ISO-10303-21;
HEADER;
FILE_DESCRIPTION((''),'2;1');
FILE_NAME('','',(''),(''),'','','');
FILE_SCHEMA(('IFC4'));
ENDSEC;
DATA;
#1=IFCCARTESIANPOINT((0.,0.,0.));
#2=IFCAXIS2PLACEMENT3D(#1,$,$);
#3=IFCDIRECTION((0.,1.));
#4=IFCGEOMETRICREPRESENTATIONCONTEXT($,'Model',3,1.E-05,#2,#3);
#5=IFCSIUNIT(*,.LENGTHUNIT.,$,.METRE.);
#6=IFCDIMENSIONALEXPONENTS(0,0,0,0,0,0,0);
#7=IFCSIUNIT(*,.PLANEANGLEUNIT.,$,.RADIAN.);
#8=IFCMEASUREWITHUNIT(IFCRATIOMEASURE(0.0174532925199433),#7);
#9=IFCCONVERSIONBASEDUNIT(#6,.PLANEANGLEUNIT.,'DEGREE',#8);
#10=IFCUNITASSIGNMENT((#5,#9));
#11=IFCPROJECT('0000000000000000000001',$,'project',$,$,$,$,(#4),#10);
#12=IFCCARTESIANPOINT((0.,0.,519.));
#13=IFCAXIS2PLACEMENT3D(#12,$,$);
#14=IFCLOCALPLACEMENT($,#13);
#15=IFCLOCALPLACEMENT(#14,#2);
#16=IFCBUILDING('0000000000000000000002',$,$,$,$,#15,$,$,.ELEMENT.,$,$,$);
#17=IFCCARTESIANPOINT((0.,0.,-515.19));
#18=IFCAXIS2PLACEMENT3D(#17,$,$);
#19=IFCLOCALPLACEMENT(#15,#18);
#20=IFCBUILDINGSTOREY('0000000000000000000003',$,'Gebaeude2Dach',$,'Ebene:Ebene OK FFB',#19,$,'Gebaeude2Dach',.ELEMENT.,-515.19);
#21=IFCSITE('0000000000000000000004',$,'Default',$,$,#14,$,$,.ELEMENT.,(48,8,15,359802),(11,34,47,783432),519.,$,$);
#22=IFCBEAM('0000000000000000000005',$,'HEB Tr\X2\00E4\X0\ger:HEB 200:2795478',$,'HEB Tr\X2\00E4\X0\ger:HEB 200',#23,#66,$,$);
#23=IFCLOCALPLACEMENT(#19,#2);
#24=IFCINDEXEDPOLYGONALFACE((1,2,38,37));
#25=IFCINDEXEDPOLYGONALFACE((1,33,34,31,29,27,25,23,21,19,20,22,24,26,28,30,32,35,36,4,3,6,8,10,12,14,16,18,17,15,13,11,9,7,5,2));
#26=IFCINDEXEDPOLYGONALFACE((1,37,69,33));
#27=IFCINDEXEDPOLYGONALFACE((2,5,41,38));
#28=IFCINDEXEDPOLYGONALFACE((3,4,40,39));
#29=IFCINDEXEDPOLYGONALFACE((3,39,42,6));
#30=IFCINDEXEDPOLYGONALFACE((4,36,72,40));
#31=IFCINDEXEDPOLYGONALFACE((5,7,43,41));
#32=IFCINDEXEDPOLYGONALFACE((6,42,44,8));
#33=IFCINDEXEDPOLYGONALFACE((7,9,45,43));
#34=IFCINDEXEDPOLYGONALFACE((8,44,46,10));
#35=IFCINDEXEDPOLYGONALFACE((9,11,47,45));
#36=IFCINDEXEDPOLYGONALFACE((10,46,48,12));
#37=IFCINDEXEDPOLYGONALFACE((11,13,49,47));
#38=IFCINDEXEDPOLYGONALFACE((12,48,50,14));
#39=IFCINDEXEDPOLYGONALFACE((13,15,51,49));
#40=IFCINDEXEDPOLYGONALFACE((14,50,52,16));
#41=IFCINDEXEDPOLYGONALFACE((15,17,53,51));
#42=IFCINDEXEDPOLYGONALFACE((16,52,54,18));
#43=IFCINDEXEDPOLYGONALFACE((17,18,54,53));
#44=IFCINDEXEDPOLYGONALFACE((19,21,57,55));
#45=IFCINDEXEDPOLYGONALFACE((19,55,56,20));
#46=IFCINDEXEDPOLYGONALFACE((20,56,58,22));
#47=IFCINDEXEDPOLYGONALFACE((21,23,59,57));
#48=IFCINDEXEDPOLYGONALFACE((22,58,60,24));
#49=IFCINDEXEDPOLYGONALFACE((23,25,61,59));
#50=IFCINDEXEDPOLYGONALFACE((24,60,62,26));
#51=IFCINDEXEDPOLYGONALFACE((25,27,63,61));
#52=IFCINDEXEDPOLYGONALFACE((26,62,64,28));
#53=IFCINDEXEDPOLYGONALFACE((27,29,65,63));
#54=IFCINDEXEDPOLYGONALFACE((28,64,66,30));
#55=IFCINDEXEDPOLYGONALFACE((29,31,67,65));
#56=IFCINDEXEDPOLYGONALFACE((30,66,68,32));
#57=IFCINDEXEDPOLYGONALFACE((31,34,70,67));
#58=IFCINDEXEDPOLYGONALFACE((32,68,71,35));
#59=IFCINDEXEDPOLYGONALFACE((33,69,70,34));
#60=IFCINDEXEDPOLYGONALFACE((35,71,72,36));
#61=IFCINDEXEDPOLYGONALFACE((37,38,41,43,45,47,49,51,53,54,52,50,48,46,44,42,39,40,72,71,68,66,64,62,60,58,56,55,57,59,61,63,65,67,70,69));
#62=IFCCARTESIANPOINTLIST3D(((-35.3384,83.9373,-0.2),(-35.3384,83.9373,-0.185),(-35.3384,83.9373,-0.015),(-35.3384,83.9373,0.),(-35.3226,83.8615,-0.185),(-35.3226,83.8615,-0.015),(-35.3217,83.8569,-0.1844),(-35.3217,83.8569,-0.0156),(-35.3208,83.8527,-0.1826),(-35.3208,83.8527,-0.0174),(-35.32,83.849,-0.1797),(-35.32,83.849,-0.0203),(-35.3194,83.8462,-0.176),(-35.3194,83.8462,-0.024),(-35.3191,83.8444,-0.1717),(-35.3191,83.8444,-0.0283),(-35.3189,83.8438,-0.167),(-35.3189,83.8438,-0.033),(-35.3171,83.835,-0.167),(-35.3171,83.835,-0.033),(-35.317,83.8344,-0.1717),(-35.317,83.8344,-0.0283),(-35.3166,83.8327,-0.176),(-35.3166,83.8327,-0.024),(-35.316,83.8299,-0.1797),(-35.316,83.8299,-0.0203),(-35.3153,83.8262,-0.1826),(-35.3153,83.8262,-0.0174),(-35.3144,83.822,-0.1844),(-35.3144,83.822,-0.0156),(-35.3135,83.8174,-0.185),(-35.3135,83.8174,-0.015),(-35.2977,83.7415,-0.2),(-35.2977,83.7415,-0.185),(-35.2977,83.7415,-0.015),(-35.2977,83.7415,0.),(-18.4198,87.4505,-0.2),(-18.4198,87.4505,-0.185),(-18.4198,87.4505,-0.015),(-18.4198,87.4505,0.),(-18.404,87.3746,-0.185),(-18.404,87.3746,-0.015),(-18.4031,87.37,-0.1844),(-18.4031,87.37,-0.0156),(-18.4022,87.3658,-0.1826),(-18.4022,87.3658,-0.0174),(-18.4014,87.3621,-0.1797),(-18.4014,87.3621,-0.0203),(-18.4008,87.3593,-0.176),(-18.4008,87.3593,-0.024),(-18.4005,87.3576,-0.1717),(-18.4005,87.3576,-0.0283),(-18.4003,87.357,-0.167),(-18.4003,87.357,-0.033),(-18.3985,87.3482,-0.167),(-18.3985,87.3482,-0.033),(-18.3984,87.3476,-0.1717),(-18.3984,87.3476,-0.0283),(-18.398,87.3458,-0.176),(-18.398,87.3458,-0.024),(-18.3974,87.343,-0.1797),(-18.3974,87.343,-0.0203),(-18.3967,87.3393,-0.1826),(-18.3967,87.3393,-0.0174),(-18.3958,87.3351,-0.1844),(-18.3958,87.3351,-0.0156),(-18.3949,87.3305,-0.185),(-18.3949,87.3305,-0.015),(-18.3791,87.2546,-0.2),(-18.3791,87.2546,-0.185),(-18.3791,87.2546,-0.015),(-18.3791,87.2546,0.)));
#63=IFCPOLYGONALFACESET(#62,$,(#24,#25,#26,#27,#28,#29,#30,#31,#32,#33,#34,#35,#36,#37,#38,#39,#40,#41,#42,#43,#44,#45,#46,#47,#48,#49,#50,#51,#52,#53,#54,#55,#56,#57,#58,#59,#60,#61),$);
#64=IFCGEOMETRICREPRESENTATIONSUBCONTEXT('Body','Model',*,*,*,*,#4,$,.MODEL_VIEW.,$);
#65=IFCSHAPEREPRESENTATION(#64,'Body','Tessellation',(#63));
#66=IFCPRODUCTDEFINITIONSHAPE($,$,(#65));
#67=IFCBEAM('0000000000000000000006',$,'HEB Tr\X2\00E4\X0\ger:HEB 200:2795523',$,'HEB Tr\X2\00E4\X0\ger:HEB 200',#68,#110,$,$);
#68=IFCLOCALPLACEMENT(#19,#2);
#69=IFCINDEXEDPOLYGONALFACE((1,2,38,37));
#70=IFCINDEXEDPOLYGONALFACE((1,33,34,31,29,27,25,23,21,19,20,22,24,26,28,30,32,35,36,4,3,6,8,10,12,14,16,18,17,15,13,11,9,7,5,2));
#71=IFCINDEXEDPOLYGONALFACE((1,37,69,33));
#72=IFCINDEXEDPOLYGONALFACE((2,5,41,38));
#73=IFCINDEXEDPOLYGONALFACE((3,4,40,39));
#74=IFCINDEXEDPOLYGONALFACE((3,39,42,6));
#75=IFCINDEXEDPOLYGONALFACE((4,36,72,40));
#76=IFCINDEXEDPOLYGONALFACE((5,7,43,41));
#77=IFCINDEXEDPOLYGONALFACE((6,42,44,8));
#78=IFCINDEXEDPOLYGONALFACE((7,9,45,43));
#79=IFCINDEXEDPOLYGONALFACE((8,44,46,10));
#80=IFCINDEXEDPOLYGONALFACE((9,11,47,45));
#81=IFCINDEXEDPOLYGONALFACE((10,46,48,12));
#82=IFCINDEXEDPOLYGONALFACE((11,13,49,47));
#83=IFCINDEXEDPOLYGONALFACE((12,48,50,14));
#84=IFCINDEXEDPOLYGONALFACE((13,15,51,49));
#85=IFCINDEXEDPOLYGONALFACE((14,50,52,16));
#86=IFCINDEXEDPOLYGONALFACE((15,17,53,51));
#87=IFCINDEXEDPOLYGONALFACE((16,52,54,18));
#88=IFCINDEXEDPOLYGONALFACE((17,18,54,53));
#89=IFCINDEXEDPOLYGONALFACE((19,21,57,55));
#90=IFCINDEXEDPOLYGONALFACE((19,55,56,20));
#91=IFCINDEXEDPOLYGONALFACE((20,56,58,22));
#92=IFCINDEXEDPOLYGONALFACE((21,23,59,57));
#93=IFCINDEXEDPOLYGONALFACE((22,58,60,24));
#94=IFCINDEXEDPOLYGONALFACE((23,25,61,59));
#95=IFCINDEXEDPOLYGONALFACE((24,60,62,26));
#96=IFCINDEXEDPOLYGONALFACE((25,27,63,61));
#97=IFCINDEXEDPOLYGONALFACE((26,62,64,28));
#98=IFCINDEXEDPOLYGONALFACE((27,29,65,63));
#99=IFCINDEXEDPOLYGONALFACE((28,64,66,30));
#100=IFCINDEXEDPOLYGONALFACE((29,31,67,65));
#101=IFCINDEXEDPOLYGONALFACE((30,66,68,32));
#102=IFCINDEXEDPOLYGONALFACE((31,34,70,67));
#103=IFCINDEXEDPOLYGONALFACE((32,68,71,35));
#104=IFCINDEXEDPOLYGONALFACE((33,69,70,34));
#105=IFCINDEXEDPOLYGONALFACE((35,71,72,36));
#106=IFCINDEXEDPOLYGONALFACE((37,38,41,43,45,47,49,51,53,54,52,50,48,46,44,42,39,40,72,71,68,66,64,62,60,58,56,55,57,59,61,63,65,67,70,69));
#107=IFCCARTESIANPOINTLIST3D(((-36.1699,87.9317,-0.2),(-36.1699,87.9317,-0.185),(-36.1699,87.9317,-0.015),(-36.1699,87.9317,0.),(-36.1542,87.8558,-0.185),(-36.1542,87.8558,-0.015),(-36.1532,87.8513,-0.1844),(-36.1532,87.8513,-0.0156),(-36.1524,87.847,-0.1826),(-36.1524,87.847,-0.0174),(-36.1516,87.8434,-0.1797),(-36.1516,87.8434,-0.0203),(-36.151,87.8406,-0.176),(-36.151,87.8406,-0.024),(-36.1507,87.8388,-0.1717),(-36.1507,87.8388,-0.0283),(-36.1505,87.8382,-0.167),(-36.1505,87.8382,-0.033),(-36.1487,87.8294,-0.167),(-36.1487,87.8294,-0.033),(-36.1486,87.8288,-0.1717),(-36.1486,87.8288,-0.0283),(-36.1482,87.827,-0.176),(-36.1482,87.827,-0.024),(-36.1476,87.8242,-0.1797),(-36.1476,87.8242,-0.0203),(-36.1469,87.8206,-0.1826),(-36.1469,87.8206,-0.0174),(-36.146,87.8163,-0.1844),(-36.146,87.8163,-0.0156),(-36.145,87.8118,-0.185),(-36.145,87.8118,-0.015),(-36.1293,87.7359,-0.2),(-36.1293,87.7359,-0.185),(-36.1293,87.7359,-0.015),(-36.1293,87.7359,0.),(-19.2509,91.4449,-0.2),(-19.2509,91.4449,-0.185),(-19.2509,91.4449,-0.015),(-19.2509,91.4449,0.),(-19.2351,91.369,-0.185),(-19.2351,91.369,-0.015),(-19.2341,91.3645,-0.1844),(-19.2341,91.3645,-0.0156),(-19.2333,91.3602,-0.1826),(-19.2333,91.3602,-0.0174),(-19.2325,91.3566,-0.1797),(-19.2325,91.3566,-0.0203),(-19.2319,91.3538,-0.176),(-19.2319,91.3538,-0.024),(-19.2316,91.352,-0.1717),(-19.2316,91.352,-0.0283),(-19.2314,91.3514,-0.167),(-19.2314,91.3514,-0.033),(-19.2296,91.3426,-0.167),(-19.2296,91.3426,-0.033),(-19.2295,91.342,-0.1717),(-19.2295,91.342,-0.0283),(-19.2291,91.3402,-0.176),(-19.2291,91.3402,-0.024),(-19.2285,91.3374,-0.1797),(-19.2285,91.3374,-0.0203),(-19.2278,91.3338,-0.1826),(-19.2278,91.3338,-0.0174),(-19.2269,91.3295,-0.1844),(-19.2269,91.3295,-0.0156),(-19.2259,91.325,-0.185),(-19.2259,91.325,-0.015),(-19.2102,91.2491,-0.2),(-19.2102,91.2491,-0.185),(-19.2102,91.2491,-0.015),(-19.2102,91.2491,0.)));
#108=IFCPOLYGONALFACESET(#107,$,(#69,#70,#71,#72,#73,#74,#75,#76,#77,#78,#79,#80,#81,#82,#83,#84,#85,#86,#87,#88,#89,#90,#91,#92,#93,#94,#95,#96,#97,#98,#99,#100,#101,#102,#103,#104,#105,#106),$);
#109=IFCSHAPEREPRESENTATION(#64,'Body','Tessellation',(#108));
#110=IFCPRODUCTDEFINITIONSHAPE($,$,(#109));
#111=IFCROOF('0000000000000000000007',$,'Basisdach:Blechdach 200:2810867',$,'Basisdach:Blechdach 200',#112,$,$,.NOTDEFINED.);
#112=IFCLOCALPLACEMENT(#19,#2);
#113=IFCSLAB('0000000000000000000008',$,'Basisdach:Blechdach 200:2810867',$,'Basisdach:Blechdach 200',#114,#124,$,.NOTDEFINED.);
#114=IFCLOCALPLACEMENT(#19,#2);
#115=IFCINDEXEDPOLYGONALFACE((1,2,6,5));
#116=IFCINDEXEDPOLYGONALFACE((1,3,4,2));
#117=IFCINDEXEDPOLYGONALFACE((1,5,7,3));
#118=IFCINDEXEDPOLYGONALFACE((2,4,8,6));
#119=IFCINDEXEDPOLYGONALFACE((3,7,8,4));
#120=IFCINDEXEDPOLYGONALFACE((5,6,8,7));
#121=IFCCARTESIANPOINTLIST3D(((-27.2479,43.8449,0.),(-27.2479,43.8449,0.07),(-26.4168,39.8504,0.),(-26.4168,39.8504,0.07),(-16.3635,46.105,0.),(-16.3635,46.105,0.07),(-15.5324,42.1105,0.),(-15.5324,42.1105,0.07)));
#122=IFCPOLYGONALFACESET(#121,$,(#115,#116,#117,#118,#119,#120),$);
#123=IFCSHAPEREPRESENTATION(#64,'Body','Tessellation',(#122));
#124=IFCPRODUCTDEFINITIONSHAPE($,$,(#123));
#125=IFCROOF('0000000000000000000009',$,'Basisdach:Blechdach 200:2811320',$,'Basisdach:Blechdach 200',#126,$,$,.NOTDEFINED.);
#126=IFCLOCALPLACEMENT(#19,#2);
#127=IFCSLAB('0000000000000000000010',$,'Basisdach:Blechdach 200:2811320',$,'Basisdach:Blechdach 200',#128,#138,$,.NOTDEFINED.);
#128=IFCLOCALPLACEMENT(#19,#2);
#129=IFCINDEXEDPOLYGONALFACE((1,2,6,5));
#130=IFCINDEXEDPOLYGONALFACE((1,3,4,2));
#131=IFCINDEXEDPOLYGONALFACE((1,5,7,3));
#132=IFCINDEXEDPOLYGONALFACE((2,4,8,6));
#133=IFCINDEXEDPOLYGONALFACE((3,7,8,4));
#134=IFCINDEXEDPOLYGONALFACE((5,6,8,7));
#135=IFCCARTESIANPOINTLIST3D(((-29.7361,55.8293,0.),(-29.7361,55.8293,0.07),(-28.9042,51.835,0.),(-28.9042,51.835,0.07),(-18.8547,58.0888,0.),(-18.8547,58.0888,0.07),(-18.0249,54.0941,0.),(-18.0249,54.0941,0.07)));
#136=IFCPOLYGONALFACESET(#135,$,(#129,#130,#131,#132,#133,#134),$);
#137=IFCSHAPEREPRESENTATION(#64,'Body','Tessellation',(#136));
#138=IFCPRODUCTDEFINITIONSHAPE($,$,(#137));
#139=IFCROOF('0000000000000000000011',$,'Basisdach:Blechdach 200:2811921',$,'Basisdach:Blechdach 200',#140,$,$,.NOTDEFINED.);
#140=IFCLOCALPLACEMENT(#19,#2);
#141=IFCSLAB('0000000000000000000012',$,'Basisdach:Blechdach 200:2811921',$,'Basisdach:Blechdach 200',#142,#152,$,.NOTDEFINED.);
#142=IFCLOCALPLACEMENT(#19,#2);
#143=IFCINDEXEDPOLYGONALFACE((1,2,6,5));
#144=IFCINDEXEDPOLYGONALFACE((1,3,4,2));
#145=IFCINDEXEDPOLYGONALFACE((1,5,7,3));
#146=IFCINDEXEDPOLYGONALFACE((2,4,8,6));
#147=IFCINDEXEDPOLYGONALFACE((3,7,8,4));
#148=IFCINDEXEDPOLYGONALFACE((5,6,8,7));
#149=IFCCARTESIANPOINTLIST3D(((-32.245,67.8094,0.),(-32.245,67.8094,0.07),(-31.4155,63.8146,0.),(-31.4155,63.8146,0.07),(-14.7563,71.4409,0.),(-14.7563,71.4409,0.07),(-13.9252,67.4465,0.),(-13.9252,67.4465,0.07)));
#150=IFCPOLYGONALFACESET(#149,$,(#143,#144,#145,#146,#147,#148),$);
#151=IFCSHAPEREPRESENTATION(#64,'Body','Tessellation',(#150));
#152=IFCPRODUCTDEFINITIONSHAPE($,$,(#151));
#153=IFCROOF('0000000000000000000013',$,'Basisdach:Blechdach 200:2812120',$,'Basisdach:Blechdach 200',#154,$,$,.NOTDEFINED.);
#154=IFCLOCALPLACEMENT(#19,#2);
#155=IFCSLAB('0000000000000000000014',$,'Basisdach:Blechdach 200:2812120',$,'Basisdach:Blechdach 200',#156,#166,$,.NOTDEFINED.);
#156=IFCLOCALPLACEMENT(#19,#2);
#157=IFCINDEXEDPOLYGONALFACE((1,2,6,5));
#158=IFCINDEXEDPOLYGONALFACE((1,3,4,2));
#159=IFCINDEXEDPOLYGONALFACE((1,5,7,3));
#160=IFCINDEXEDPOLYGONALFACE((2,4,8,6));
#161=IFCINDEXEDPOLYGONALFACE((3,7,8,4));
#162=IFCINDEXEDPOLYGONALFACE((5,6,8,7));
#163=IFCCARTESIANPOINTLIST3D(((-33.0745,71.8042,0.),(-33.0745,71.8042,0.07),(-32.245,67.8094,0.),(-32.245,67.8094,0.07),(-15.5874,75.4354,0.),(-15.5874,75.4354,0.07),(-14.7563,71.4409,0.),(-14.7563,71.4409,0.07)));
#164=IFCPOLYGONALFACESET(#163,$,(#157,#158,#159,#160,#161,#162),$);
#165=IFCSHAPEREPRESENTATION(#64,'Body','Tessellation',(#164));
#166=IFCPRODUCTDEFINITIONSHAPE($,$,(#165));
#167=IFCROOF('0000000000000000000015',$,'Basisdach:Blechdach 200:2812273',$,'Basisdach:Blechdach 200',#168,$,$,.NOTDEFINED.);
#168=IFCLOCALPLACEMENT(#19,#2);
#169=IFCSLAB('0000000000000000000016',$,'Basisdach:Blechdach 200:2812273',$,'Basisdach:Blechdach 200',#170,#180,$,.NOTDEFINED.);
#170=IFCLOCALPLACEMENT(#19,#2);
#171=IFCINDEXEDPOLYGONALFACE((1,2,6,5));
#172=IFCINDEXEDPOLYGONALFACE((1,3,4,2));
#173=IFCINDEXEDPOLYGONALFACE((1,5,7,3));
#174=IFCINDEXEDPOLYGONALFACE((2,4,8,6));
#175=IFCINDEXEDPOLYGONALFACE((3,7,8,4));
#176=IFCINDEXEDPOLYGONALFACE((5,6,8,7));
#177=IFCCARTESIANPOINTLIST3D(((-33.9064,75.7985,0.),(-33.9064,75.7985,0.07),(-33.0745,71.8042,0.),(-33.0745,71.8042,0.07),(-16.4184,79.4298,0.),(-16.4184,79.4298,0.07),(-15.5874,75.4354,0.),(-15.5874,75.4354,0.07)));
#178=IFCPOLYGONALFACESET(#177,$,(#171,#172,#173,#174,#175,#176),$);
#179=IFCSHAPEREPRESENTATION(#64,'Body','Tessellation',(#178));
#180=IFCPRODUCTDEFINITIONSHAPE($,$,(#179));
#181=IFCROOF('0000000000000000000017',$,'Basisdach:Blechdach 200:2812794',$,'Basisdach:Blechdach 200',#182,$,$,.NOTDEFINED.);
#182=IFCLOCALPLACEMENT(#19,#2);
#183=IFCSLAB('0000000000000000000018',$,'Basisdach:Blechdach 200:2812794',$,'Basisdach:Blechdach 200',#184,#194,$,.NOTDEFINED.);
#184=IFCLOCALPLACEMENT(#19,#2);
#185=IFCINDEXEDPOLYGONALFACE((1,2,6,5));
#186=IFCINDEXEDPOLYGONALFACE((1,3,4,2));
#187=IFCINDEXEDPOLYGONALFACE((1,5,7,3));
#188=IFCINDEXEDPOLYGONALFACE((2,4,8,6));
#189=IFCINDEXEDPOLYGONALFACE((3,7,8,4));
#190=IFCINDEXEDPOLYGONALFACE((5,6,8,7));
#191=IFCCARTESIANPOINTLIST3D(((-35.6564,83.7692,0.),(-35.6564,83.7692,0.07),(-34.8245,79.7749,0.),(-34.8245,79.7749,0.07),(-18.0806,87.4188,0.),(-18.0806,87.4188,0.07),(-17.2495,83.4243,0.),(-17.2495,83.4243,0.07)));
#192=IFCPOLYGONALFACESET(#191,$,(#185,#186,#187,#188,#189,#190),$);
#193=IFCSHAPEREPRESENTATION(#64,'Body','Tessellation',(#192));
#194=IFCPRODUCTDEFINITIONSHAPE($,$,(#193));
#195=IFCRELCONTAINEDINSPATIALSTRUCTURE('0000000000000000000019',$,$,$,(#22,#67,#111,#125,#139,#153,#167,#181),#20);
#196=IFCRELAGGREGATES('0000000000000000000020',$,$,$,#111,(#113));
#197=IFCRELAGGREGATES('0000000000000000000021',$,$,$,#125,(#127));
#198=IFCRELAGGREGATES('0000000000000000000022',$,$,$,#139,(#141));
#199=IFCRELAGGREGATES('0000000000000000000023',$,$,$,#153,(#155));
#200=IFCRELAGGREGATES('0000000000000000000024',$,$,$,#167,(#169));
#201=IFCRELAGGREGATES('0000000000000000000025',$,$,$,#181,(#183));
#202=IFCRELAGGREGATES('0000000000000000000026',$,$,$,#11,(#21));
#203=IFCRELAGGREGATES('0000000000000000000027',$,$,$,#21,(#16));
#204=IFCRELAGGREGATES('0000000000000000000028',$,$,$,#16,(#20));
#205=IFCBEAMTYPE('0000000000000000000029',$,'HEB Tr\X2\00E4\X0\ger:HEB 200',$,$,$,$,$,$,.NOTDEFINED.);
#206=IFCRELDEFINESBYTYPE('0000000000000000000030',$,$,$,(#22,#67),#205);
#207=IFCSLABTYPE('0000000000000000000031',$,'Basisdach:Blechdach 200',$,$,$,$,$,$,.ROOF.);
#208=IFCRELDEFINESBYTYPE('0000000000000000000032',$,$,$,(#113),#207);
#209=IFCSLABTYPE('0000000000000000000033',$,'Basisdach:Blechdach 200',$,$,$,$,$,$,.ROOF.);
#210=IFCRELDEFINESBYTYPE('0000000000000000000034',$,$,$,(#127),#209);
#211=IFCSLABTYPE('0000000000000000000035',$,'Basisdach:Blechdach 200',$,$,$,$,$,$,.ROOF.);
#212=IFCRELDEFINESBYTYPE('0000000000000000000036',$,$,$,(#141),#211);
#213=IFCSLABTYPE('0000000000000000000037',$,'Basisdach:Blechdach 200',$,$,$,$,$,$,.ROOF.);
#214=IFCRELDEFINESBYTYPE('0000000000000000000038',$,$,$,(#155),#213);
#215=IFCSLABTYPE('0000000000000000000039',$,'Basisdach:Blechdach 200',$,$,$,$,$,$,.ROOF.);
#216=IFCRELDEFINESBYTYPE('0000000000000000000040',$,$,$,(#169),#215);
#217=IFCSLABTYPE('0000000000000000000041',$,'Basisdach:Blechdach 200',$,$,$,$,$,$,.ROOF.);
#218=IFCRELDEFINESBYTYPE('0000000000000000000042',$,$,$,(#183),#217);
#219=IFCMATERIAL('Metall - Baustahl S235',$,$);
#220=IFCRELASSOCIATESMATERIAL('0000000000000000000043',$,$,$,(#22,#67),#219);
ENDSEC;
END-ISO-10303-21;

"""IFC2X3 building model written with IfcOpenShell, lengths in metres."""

from ifc_helpers import new_model, entity, si_unit, converted_unit, direction, frame, frame_2d, origin, place, context, subcontext, project, spatial, polyline, i_section, outline, extrude, material, type_object, element, aggregate, save


model = new_model("IFC2X3")

# Units and contexts
model_context = context("Model", 3, precision=1e-05, world=origin(), true_north=direction((0.0, 1.0)))
body_context = subcontext(model_context, "Body", "Model", "MODEL_VIEW")
ifc_project = project(units=[si_unit("LENGTHUNIT", "METRE"), converted_unit("PLANEANGLEUNIT", "DEGREE", entity("IfcRatioMeasure", 0.0174532925199433), si_unit("PLANEANGLEUNIT", "RADIAN"), dimensions=[0, 0, 0, 0, 0, 0, 0])], contexts=[model_context])

# Site, building, storey
site_placement = place(None, frame((0.0, 0.0, 519.0)))
site = spatial("IfcSite", under=ifc_project, at=site_placement, Name="Default", CompositionType="ELEMENT", RefLatitude=(48, 8, 15, 359802), RefLongitude=(11, 34, 47, 783432), RefElevation=519.0)
building_placement = place(site_placement, origin())
building = spatial("IfcBuilding", under=site, at=building_placement, CompositionType="ELEMENT")
storey_placement = place(building_placement, frame((0.0, 0.0, -515.19)))
storey = spatial("IfcBuildingStorey", under=building, at=storey_placement, Name="Gebaeude2Dach", ObjectType="Ebene:Ebene OK FFB", LongName="Gebaeude2Dach", CompositionType="ELEMENT", Elevation=-515.19)

# Beams
ifc_material = material(Name="Metall - Baustahl S235")
beam_type = type_object("IfcBeamType", Name="HEB Träger:HEB 200", PredefinedType="NOTDEFINED")
beam_1_placement = place(storey_placement, frame((-18.2861, 87.3761, 0.0), z_axis=(0.0, 0.0, 1.0), x_axis=(-0.979114, -0.203311, 0.0)))
element("IfcBeam", 1, at=beam_1_placement, inside=storey, type_object=beam_type, material=ifc_material, Name="HEB Träger:HEB 200:2795478", ObjectType="HEB Träger:HEB 200", context=body_context, shape_type="SweptSolid", body=[
    extrude(i_section(OverallWidth=0.2, OverallDepth=0.2, WebThickness=0.009, FlangeThickness=0.015, FilletRadius=0.018, at=frame_2d((0.0, 0.0), x_axis=(0.0, 1.0))), frame((0.1158, 0.0, -0.1), z_axis=(1.0, 0.0, 0.0), x_axis=(0.0, 0.0, -1.0)), (0.0, 0.0, 1.0), 17.2795),
])
beam_2_placement = place(storey_placement, frame((-19.1171, 91.3706, 0.0), z_axis=(0.0, 0.0, 1.0), x_axis=(-0.979114, -0.203311, 0.0)))
element("IfcBeam", 2, at=beam_2_placement, inside=storey, type_object=beam_type, material=ifc_material, Name="HEB Träger:HEB 200:2795523", ObjectType="HEB Träger:HEB 200", context=body_context, shape_type="SweptSolid", body=[
    extrude(i_section(OverallWidth=0.2, OverallDepth=0.2, WebThickness=0.009, FlangeThickness=0.015, FilletRadius=0.018, at=frame_2d((0.0, 0.0), x_axis=(0.0, 1.0))), frame((0.1158, 0.0, -0.1), z_axis=(1.0, 0.0, 0.0), x_axis=(0.0, 0.0, -1.0)), (0.0, 0.0, 1.0), 17.28),
])

# Roofs, slabs
roof_1_placement = place(storey_placement, frame((-27.2479, 39.8504, 0.0)))
roof_1 = element("IfcRoof", 3, at=roof_1_placement, inside=storey, Name="Basisdach:Blechdach 200:2810867", ObjectType="Basisdach:Blechdach 200", ShapeType="NOTDEFINED")
slab_type_1 = type_object("IfcSlabType", Name="Basisdach:Blechdach 200", PredefinedType="ROOF")
slab_1_placement = place(roof_1_placement, origin())
slab_1 = element("IfcSlab", 4, at=slab_1_placement, type_object=slab_type_1, Name="Basisdach:Blechdach 200:2810867", ObjectType="Basisdach:Blechdach 200", PredefinedType="NOTDEFINED", context=body_context, shape_type="SweptSolid", body=[
    extrude(outline(polyline([(5.8577, -0.8672), (5.0267, 3.1273), (-5.8577, 0.8672), (-5.0267, -3.1273), (5.8577, -0.8672)])), frame((5.8577, 3.1273, 0.0)), (0.0, 0.0, 1.0), 0.07),
])
aggregate(roof_1, [slab_1])
roof_2_placement = place(storey_placement, frame((-29.7361, 51.835, 0.0)))
roof_2 = element("IfcRoof", 5, at=roof_2_placement, inside=storey, Name="Basisdach:Blechdach 200:2811320", ObjectType="Basisdach:Blechdach 200", ShapeType="NOTDEFINED")
slab_type_2 = type_object("IfcSlabType", Name="Basisdach:Blechdach 200", PredefinedType="ROOF")
slab_2_placement = place(roof_2_placement, origin())
slab_2 = element("IfcSlab", 6, at=slab_2_placement, type_object=slab_type_2, Name="Basisdach:Blechdach 200:2811320", ObjectType="Basisdach:Blechdach 200", PredefinedType="NOTDEFINED", context=body_context, shape_type="SweptSolid", body=[
    extrude(outline(polyline([(5.8556, -0.8678), (5.0258, 3.1269), (-5.8556, 0.8674), (-5.0237, -3.1269), (5.8556, -0.8678)])), frame((5.8556, 3.1269, 0.0)), (0.0, 0.0, 1.0), 0.07),
])
aggregate(roof_2, [slab_2])
roof_3_placement = place(storey_placement, frame((-32.245, 63.8146, 0.0)))
roof_3 = element("IfcRoof", 7, at=roof_3_placement, inside=storey, Name="Basisdach:Blechdach 200:2811921", ObjectType="Basisdach:Blechdach 200", ShapeType="NOTDEFINED")
slab_type_3 = type_object("IfcSlabType", Name="Basisdach:Blechdach 200", PredefinedType="ROOF")
slab_3_placement = place(roof_3_placement, origin())
slab_3 = element("IfcSlab", 8, at=slab_3_placement, type_object=slab_type_3, Name="Basisdach:Blechdach 200:2811921", ObjectType="Basisdach:Blechdach 200", PredefinedType="NOTDEFINED", context=body_context, shape_type="SweptSolid", body=[
    extrude(outline(polyline([(9.1599, -0.1813), (8.3288, 3.8131), (-9.1599, 0.1816), (-8.3304, -3.8131), (9.1599, -0.1813)])), frame((9.1599, 3.8131, 0.0)), (0.0, 0.0, 1.0), 0.07),
])
aggregate(roof_3, [slab_3])
roof_4_placement = place(storey_placement, frame((-33.0745, 67.8094, 0.0)))
roof_4 = element("IfcRoof", 9, at=roof_4_placement, inside=storey, Name="Basisdach:Blechdach 200:2812120", ObjectType="Basisdach:Blechdach 200", ShapeType="NOTDEFINED")
slab_type_4 = type_object("IfcSlabType", Name="Basisdach:Blechdach 200", PredefinedType="ROOF")
slab_4_placement = place(roof_4_placement, origin())
slab_4 = element("IfcSlab", 10, at=slab_4_placement, type_object=slab_type_4, Name="Basisdach:Blechdach 200:2812120", ObjectType="Basisdach:Blechdach 200", PredefinedType="NOTDEFINED", context=body_context, shape_type="SweptSolid", body=[
    extrude(outline(polyline([(9.1591, -0.1815), (8.328, 3.813), (-9.1591, 0.1818), (-8.3296, -3.813), (9.1591, -0.1815)])), frame((9.1591, 3.813, 0.0)), (0.0, 0.0, 1.0), 0.07),
])
aggregate(roof_4, [slab_4])
roof_5_placement = place(storey_placement, frame((-33.9064, 71.8042, 0.0)))
roof_5 = element("IfcRoof", 11, at=roof_5_placement, inside=storey, Name="Basisdach:Blechdach 200:2812273", ObjectType="Basisdach:Blechdach 200", ShapeType="NOTDEFINED")
slab_type_5 = type_object("IfcSlabType", Name="Basisdach:Blechdach 200", PredefinedType="ROOF")
slab_5_placement = place(roof_5_placement, origin())
slab_5 = element("IfcSlab", 12, at=slab_5_placement, type_object=slab_type_5, Name="Basisdach:Blechdach 200:2812273", ObjectType="Basisdach:Blechdach 200", PredefinedType="NOTDEFINED", context=body_context, shape_type="SweptSolid", body=[
    extrude(outline(polyline([(9.1595, -0.1816), (8.3285, 3.8128), (-9.1595, 0.1815), (-8.3276, -3.8128), (9.1595, -0.1816)])), frame((9.1595, 3.8128, 0.0)), (0.0, 0.0, 1.0), 0.07),
])
aggregate(roof_5, [slab_5])
roof_6_placement = place(storey_placement, frame((-35.6564, 79.7749, 0.0)))
roof_6 = element("IfcRoof", 13, at=roof_6_placement, inside=storey, Name="Basisdach:Blechdach 200:2812794", ObjectType="Basisdach:Blechdach 200", ShapeType="NOTDEFINED")
slab_type_6 = type_object("IfcSlabType", Name="Basisdach:Blechdach 200", PredefinedType="ROOF")
slab_6_placement = place(roof_6_placement, origin())
slab_6 = element("IfcSlab", 14, at=slab_6_placement, type_object=slab_type_6, Name="Basisdach:Blechdach 200:2812794", ObjectType="Basisdach:Blechdach 200", PredefinedType="NOTDEFINED", context=body_context, shape_type="SweptSolid", body=[
    extrude(outline(polyline([(9.2034, -0.1725), (8.3723, 3.8219), (-9.2034, 0.1724), (-8.3715, -3.8219), (9.2034, -0.1725)])), frame((9.2034, 3.8219, 0.0)), (0.0, 0.0, 1.0), 0.07),
])
aggregate(roof_6, [slab_6])

save(model, "model.ifc")
